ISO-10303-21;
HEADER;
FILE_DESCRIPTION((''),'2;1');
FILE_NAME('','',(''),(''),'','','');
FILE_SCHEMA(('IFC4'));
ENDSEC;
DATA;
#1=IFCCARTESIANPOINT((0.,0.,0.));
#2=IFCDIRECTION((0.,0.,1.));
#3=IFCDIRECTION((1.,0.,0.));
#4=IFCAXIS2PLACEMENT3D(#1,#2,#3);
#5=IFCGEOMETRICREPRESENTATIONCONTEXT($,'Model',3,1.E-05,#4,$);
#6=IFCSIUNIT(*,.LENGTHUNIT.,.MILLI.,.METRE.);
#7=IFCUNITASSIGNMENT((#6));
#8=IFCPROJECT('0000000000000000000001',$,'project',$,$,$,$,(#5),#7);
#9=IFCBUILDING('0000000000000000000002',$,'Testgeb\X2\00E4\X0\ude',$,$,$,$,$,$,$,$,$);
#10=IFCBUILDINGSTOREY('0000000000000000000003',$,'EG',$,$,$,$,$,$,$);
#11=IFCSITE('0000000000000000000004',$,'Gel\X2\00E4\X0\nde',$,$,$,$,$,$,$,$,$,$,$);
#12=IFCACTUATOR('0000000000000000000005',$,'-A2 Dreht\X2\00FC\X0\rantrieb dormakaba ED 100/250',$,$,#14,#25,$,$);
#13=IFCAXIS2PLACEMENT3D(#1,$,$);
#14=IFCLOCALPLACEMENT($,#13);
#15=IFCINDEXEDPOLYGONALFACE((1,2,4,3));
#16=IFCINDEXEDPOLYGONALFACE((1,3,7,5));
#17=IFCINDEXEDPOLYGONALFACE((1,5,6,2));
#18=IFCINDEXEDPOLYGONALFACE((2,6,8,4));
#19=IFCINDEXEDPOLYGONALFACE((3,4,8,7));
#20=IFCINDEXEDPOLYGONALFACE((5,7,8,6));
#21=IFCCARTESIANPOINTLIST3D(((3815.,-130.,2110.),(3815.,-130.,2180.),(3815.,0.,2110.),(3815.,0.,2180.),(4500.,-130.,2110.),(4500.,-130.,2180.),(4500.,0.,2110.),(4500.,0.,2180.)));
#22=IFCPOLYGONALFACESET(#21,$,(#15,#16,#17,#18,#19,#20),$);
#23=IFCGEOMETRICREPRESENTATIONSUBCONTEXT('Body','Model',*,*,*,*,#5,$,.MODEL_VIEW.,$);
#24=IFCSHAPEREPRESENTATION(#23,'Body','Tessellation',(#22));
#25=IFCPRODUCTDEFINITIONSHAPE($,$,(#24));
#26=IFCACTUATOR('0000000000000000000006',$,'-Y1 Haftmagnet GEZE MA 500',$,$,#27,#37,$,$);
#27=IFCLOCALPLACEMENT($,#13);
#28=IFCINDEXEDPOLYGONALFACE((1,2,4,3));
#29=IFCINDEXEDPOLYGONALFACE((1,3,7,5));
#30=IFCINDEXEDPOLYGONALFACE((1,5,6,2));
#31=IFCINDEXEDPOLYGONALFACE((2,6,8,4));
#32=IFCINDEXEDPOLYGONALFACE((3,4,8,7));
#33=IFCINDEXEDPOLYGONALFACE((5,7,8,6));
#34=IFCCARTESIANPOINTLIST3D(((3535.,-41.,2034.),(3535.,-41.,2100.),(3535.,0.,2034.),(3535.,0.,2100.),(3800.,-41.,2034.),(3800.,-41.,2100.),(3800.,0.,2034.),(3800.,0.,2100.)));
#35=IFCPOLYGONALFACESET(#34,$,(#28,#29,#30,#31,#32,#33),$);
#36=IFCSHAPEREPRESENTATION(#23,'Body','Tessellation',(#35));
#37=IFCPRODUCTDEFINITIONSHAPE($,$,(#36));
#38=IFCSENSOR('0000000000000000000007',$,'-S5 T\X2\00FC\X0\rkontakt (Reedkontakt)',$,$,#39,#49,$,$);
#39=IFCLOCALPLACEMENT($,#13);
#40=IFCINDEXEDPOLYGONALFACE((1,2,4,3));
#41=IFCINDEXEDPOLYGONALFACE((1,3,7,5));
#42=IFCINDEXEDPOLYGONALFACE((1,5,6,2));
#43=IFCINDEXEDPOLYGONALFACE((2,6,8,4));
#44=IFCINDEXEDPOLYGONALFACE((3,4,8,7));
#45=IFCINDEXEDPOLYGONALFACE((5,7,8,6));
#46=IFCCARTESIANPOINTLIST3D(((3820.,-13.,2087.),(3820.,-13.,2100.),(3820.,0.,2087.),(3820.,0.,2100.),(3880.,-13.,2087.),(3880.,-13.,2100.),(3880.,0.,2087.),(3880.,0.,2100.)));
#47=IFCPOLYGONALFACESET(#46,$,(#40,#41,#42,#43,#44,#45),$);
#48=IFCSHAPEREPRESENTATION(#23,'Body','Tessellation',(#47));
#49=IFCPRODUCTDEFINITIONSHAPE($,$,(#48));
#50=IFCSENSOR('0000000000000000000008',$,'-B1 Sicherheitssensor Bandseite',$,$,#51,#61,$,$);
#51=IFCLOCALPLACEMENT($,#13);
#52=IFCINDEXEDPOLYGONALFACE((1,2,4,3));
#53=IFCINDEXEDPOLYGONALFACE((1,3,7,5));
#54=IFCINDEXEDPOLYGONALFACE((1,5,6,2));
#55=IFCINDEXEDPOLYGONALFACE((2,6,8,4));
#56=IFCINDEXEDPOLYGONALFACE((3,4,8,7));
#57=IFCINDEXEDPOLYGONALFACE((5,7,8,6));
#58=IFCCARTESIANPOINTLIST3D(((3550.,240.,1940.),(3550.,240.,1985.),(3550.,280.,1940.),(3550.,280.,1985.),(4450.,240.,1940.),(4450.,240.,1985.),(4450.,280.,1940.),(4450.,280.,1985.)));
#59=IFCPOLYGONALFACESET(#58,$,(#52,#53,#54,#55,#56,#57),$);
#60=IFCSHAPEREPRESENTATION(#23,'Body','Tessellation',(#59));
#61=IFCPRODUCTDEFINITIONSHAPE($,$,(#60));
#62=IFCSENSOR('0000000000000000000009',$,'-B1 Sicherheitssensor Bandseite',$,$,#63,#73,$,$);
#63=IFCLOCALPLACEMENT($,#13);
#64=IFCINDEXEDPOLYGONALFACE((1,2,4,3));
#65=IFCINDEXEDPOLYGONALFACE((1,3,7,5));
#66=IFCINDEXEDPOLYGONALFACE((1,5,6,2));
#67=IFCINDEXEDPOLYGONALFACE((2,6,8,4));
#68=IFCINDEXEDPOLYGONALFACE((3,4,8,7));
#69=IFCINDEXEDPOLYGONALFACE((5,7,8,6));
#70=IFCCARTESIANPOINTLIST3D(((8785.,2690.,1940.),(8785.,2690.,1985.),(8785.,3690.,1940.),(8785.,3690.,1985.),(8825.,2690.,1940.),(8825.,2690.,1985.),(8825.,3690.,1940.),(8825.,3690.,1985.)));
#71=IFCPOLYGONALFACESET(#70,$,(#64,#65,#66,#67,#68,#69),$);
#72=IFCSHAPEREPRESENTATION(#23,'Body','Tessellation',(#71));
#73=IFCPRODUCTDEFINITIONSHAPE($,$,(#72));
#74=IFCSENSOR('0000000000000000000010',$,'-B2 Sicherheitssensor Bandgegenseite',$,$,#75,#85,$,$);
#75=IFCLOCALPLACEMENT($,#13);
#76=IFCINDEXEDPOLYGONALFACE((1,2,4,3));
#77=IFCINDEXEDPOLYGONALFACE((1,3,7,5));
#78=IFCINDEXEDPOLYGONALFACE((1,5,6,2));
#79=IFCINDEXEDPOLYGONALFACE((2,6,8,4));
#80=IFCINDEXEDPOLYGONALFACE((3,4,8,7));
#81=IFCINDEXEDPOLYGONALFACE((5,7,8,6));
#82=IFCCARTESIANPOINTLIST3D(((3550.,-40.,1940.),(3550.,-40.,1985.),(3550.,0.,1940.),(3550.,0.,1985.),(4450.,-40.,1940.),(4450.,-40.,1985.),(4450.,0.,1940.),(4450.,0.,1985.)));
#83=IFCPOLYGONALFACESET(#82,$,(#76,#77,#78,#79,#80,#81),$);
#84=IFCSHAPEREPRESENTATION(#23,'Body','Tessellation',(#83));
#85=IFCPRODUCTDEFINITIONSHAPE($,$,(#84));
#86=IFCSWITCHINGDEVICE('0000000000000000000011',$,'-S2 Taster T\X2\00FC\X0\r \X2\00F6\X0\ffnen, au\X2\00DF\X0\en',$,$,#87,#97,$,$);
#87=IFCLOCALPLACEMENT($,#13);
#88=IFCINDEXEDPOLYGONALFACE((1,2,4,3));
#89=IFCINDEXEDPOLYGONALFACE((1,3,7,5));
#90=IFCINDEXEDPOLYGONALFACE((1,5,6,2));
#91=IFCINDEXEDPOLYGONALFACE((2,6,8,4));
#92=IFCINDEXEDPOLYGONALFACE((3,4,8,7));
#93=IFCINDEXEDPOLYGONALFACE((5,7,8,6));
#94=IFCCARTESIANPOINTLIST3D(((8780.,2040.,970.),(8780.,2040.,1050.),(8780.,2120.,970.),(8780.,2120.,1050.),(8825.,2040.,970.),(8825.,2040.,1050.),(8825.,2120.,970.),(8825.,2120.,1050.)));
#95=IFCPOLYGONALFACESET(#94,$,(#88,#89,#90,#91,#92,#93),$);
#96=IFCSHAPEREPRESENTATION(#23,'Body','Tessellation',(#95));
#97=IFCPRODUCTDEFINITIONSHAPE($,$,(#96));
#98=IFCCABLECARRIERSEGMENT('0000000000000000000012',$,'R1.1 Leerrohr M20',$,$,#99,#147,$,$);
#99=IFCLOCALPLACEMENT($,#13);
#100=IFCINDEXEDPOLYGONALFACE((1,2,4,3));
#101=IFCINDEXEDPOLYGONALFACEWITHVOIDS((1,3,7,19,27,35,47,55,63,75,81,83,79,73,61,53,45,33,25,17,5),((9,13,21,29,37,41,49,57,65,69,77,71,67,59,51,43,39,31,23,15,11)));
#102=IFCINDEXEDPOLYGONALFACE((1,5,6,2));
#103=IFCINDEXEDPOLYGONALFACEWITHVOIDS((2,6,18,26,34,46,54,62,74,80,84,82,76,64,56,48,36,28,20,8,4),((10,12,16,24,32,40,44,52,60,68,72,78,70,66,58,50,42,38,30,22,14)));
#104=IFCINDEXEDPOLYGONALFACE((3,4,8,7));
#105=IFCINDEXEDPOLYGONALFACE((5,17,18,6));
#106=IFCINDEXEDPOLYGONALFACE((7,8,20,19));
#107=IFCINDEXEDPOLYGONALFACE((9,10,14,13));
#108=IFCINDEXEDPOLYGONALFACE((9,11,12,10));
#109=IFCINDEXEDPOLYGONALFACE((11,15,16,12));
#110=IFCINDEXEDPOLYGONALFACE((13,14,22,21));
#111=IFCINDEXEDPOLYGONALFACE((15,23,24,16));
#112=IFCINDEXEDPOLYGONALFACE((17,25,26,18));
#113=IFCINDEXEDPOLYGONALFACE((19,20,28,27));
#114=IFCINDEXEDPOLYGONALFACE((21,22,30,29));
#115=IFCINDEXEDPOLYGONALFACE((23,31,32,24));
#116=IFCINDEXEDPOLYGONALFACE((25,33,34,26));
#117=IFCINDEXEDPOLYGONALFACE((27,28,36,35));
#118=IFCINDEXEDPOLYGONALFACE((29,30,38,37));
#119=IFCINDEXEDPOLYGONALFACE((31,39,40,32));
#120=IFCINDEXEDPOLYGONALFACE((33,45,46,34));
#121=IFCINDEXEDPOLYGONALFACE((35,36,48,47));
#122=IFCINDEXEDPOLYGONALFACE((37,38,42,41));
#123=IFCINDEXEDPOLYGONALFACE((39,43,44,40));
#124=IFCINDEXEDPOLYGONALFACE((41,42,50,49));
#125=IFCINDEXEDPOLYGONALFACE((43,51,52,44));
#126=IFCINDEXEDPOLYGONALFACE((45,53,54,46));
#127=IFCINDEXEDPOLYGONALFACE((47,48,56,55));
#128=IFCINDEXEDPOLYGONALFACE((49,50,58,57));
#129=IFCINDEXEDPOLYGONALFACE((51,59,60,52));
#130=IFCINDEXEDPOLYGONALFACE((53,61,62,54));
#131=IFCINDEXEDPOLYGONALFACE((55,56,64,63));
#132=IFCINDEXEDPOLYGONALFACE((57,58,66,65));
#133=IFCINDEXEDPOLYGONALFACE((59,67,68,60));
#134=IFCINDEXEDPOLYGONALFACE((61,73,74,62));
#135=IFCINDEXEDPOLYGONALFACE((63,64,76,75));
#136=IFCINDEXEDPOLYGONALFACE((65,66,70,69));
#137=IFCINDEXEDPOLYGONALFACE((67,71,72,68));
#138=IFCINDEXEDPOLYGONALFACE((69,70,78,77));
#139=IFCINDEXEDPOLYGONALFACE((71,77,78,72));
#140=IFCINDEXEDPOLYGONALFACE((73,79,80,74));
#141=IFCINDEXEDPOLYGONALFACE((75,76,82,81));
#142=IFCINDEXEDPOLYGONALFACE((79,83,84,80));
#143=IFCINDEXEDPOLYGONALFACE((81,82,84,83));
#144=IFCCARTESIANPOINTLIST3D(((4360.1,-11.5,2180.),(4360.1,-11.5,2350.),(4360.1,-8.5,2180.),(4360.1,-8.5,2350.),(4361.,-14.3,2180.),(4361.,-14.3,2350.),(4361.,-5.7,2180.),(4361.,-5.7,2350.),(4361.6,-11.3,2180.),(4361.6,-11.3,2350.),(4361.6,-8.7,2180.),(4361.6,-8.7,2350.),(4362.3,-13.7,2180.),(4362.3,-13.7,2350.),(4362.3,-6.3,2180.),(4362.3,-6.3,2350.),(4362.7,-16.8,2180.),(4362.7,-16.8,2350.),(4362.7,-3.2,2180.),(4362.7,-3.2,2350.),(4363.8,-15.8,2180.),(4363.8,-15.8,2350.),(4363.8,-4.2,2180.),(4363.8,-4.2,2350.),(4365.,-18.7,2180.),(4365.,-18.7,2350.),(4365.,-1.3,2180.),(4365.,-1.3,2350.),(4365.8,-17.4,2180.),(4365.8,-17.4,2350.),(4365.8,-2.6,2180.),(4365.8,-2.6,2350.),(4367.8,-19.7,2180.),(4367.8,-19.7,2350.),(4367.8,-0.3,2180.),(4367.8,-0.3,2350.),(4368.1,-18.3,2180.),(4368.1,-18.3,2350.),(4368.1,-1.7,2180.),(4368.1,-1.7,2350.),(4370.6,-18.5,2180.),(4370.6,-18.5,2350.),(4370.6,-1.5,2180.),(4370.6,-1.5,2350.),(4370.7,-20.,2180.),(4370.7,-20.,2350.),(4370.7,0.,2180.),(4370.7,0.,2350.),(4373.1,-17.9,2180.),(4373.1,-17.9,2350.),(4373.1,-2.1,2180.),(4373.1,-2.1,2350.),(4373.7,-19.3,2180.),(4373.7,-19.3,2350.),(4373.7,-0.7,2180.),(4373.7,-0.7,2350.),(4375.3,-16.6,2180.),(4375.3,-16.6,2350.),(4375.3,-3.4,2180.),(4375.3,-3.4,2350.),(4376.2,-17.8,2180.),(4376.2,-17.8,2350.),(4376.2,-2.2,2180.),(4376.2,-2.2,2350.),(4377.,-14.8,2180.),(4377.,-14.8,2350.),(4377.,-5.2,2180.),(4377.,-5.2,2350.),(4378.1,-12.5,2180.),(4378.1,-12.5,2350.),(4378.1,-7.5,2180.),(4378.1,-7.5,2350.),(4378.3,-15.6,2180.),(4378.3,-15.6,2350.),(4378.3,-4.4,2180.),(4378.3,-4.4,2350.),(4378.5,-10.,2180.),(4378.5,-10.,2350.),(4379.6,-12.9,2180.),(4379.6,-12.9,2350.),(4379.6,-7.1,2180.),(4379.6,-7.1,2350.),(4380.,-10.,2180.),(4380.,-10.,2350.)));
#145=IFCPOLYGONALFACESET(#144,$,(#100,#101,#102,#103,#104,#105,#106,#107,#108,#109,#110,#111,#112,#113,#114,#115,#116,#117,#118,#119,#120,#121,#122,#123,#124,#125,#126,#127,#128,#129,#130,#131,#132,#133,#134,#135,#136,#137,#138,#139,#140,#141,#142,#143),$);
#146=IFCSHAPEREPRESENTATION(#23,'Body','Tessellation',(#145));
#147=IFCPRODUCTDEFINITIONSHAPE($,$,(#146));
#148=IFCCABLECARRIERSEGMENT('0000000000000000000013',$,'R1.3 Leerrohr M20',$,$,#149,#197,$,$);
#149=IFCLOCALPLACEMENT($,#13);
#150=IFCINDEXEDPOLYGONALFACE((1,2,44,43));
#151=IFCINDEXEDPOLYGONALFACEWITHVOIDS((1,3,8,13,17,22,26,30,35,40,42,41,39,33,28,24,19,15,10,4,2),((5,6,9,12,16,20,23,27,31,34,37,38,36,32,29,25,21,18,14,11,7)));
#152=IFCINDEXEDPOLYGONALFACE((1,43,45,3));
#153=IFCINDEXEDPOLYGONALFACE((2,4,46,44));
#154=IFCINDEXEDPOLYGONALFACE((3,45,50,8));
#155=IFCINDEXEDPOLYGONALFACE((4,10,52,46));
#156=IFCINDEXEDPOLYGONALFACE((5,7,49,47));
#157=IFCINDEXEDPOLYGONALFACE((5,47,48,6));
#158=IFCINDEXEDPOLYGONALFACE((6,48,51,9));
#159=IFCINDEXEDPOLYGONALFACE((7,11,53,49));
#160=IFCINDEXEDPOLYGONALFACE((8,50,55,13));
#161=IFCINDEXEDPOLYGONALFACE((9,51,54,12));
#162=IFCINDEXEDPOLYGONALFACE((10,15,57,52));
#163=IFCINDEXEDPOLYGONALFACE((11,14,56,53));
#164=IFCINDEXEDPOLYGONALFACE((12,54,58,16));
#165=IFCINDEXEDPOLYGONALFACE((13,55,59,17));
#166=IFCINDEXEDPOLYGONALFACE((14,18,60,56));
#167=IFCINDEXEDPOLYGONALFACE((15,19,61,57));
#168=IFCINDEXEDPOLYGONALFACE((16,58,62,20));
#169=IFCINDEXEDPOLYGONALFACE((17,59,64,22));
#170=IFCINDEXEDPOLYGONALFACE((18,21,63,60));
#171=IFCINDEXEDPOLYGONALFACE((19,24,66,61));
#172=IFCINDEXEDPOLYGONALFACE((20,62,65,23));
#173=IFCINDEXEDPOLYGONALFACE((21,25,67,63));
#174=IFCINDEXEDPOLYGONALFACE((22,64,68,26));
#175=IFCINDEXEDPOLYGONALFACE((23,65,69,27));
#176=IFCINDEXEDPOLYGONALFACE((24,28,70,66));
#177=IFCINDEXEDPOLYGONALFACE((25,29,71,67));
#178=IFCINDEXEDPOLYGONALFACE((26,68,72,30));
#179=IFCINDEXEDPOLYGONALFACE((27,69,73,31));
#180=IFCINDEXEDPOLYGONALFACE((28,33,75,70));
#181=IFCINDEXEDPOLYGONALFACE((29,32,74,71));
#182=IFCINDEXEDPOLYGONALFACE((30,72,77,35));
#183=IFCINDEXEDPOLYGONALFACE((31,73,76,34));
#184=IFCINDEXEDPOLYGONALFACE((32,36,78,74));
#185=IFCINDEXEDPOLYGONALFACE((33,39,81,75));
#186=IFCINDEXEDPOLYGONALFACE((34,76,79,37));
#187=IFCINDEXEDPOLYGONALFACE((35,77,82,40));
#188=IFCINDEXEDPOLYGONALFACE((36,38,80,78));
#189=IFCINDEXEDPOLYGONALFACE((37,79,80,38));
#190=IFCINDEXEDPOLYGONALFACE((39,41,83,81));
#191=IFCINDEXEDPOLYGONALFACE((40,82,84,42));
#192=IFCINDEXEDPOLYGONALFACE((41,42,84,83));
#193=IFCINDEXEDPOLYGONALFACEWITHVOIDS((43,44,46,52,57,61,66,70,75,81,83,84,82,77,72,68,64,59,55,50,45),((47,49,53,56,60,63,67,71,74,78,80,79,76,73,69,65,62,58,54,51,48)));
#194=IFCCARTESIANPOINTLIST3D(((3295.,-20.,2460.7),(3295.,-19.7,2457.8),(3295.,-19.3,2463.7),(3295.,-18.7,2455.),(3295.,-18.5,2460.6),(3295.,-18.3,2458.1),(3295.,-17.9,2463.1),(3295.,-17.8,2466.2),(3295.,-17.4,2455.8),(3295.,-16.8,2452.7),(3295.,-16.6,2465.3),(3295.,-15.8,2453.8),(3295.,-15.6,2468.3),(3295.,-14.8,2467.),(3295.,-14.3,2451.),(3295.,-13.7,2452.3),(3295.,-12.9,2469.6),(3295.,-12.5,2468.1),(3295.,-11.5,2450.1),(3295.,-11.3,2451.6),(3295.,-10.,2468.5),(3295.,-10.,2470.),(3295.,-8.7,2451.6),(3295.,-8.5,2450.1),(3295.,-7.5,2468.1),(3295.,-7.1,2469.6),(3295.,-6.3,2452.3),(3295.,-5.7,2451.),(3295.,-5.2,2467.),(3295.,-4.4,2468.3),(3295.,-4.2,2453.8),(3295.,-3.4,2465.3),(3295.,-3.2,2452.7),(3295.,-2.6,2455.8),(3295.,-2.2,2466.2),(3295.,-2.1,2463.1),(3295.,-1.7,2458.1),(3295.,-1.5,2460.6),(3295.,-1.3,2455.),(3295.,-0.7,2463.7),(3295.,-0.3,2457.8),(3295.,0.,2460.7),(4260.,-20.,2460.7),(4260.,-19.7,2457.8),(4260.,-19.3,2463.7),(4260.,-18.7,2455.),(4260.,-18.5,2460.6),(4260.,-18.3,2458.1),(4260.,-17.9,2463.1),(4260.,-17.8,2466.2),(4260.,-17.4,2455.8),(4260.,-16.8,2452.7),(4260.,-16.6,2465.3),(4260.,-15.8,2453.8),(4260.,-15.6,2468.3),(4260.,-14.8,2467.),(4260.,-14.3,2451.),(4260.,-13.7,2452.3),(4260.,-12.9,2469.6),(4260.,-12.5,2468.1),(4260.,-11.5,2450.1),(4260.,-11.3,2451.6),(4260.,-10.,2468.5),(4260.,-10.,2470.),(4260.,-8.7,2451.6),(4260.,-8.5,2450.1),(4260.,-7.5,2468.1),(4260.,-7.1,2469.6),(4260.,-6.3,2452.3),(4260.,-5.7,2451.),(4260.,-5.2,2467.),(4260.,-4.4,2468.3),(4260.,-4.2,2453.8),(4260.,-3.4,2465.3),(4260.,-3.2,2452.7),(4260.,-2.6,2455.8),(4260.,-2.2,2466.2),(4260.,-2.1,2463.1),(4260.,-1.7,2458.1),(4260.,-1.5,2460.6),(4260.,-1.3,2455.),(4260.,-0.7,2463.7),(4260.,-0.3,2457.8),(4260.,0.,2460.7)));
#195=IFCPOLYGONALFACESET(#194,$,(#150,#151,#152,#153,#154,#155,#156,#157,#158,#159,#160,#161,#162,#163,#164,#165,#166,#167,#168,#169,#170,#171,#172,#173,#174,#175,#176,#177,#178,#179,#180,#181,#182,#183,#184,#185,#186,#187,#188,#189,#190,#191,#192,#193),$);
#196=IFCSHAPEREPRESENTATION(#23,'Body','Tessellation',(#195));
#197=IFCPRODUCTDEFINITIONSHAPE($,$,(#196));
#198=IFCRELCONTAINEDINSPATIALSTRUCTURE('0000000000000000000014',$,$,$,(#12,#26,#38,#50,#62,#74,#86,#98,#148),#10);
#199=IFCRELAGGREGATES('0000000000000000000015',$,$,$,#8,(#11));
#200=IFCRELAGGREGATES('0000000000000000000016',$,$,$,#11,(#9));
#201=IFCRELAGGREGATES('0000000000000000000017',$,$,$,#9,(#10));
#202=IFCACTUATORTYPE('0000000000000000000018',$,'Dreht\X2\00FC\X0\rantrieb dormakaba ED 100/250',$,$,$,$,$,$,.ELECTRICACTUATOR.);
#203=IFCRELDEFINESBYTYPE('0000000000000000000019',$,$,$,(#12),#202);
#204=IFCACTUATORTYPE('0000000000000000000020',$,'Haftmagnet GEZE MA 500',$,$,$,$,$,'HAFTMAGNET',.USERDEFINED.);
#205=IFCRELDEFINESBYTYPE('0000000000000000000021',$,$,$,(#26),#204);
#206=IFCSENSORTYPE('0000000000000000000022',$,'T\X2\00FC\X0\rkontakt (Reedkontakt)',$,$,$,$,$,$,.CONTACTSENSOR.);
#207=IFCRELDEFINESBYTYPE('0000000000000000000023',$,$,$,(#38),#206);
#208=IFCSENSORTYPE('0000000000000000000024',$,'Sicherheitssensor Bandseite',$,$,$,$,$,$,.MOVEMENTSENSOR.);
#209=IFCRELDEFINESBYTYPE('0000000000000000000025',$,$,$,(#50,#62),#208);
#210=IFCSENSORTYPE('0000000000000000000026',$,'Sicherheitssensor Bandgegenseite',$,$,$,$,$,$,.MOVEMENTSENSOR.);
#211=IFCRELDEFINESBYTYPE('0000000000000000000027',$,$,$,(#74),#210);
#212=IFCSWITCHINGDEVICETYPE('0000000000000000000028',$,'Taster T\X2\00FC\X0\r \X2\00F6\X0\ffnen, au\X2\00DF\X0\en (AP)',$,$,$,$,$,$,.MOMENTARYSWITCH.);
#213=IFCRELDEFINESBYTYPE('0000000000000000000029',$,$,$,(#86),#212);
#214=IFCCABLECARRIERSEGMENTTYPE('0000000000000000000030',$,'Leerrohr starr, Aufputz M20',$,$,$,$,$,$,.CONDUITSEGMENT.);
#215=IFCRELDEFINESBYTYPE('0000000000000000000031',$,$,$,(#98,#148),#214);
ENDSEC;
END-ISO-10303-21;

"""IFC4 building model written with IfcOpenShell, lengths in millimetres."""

from ifc_helpers import new_model, si_unit, frame, frame_2d, origin_with_axes, place, context, subcontext, project, spatial, rectangle, hollow_circle, extrude, type_object, element, save


model = new_model("IFC4")

# Units and contexts
model_context = context("Model", 3, precision=1e-05, world=origin_with_axes())
body_context = subcontext(model_context, "Body", "Model", "MODEL_VIEW")
ifc_project = project(units=[si_unit("LENGTHUNIT", "METRE", prefix="MILLI")], contexts=[model_context])

# Site, building, storey
site = spatial("IfcSite", under=ifc_project, Name="Gelände")
building = spatial("IfcBuilding", under=site, Name="Testgebäude")
storey = spatial("IfcBuildingStorey", under=building, Name="EG")

# Actuators
actuator_type_1 = type_object("IfcActuatorType", Name="Drehtürantrieb dormakaba ED 100/250", PredefinedType="ELECTRICACTUATOR")
actuator_1_placement = place(None, frame((3815.0, -130.0, 2110.0), z_axis=(0.0, 0.0, 1.0), x_axis=(1.0, 0.0, 0.0)))
element("IfcActuator", 1, at=actuator_1_placement, inside=storey, type_object=actuator_type_1, Name="-A2 Drehtürantrieb dormakaba ED 100/250", context=body_context, shape_type="SweptSolid", body=[
    extrude(rectangle(XDim=685.0, YDim=130.0, at=frame_2d((342.5, 65.0))), None, (0.0, 0.0, 1.0), 70.0),
])
actuator_type_2 = type_object("IfcActuatorType", Name="Haftmagnet GEZE MA 500", ElementType="HAFTMAGNET", PredefinedType="USERDEFINED")
actuator_2_placement = place(None, frame((3535.0, -41.0, 2034.0), z_axis=(0.0, 0.0, 1.0), x_axis=(1.0, 0.0, 0.0)))
element("IfcActuator", 2, at=actuator_2_placement, inside=storey, type_object=actuator_type_2, Name="-Y1 Haftmagnet GEZE MA 500", context=body_context, shape_type="SweptSolid", body=[
    extrude(rectangle(XDim=265.0, YDim=41.0, at=frame_2d((132.5, 20.5))), None, (0.0, 0.0, 1.0), 66.0),
])

# Sensors
sensor_type_1 = type_object("IfcSensorType", Name="Türkontakt (Reedkontakt)", PredefinedType="CONTACTSENSOR")
sensor_1_placement = place(None, frame((3820.0, -13.0, 2087.0), z_axis=(0.0, 0.0, 1.0), x_axis=(1.0, 0.0, 0.0)))
element("IfcSensor", 3, at=sensor_1_placement, inside=storey, type_object=sensor_type_1, Name="-S5 Türkontakt (Reedkontakt)", context=body_context, shape_type="SweptSolid", body=[
    extrude(rectangle(XDim=60.0, YDim=13.0, at=frame_2d((30.0, 6.5))), None, (0.0, 0.0, 1.0), 13.0),
])
sensor_type_2 = type_object("IfcSensorType", Name="Sicherheitssensor Bandseite", PredefinedType="MOVEMENTSENSOR")
sensor_2_placement = place(None, frame((3550.0, 240.0, 1940.0), z_axis=(0.0, 0.0, 1.0), x_axis=(1.0, 0.0, 0.0)))
element("IfcSensor", 4, at=sensor_2_placement, inside=storey, type_object=sensor_type_2, Name="-B1 Sicherheitssensor Bandseite", context=body_context, shape_type="SweptSolid", body=[
    extrude(rectangle(XDim=900.0, YDim=40.0, at=frame_2d((450.0, 20.0))), None, (0.0, 0.0, 1.0), 45.0),
])
sensor_3_placement = place(None, frame((8825.0, 2690.0, 1940.0), z_axis=(0.0, 0.0, 1.0), x_axis=(0.0, 1.0, 0.0)))
element("IfcSensor", 5, at=sensor_3_placement, inside=storey, type_object=sensor_type_2, Name="-B1 Sicherheitssensor Bandseite", context=body_context, shape_type="SweptSolid", body=[
    extrude(rectangle(XDim=1000.0, YDim=40.0, at=frame_2d((500.0, 20.0))), None, (0.0, 0.0, 1.0), 45.0),
])
sensor_type_3 = type_object("IfcSensorType", Name="Sicherheitssensor Bandgegenseite", PredefinedType="MOVEMENTSENSOR")
sensor_4_placement = place(None, frame((3550.0, -40.0, 1940.0), z_axis=(0.0, 0.0, 1.0), x_axis=(1.0, 0.0, 0.0)))
element("IfcSensor", 6, at=sensor_4_placement, inside=storey, type_object=sensor_type_3, Name="-B2 Sicherheitssensor Bandgegenseite", context=body_context, shape_type="SweptSolid", body=[
    extrude(rectangle(XDim=900.0, YDim=40.0, at=frame_2d((450.0, 20.0))), None, (0.0, 0.0, 1.0), 45.0),
])

# Switching device
switching_device_type = type_object("IfcSwitchingDeviceType", Name="Taster Tür öffnen, außen (AP)", PredefinedType="MOMENTARYSWITCH")
switching_device_placement = place(None, frame((8825.0, 2040.0, 970.0), z_axis=(0.0, 0.0, 1.0), x_axis=(0.0, 1.0, 0.0)))
element("IfcSwitchingDevice", 7, at=switching_device_placement, inside=storey, type_object=switching_device_type, Name="-S2 Taster Tür öffnen, außen", context=body_context, shape_type="SweptSolid", body=[
    extrude(rectangle(XDim=80.0, YDim=45.0, at=frame_2d((40.0, 22.5))), None, (0.0, 0.0, 1.0), 80.0),
])

# Cable carrier segments
cable_carrier_segment_type_1 = type_object("IfcCableCarrierSegmentType", Name="Leerrohr starr, Aufputz M20", PredefinedType="CONDUITSEGMENT")
cable_carrier_segment_1_placement = place(None, frame((4370.0, -10.0, 2180.0), z_axis=(0.0, 0.0, 1.0), x_axis=(1.0, 0.0, 0.0)))
element("IfcCableCarrierSegment", 8, at=cable_carrier_segment_1_placement, inside=storey, type_object=cable_carrier_segment_type_1, Name="R1.1 Leerrohr M20", context=body_context, shape_type="SweptSolid", body=[
    extrude(hollow_circle(Radius=10.0, WallThickness=1.5), None, (0.0, 0.0, 1.0), 170.0),
])
cable_carrier_segment_2_placement = place(None, frame((4260.0, -10.0, 2460.0), z_axis=(-1.0, 0.0, 0.0), x_axis=(0.0, 0.0, 1.0)))
element("IfcCableCarrierSegment", 9, at=cable_carrier_segment_2_placement, inside=storey, type_object=cable_carrier_segment_type_1, Name="R1.3 Leerrohr M20", context=body_context, shape_type="SweptSolid", body=[
    extrude(hollow_circle(Radius=10.0, WallThickness=1.5), None, (0.0, 0.0, 1.0), 965.0),
])

save(model, "model.ifc")
